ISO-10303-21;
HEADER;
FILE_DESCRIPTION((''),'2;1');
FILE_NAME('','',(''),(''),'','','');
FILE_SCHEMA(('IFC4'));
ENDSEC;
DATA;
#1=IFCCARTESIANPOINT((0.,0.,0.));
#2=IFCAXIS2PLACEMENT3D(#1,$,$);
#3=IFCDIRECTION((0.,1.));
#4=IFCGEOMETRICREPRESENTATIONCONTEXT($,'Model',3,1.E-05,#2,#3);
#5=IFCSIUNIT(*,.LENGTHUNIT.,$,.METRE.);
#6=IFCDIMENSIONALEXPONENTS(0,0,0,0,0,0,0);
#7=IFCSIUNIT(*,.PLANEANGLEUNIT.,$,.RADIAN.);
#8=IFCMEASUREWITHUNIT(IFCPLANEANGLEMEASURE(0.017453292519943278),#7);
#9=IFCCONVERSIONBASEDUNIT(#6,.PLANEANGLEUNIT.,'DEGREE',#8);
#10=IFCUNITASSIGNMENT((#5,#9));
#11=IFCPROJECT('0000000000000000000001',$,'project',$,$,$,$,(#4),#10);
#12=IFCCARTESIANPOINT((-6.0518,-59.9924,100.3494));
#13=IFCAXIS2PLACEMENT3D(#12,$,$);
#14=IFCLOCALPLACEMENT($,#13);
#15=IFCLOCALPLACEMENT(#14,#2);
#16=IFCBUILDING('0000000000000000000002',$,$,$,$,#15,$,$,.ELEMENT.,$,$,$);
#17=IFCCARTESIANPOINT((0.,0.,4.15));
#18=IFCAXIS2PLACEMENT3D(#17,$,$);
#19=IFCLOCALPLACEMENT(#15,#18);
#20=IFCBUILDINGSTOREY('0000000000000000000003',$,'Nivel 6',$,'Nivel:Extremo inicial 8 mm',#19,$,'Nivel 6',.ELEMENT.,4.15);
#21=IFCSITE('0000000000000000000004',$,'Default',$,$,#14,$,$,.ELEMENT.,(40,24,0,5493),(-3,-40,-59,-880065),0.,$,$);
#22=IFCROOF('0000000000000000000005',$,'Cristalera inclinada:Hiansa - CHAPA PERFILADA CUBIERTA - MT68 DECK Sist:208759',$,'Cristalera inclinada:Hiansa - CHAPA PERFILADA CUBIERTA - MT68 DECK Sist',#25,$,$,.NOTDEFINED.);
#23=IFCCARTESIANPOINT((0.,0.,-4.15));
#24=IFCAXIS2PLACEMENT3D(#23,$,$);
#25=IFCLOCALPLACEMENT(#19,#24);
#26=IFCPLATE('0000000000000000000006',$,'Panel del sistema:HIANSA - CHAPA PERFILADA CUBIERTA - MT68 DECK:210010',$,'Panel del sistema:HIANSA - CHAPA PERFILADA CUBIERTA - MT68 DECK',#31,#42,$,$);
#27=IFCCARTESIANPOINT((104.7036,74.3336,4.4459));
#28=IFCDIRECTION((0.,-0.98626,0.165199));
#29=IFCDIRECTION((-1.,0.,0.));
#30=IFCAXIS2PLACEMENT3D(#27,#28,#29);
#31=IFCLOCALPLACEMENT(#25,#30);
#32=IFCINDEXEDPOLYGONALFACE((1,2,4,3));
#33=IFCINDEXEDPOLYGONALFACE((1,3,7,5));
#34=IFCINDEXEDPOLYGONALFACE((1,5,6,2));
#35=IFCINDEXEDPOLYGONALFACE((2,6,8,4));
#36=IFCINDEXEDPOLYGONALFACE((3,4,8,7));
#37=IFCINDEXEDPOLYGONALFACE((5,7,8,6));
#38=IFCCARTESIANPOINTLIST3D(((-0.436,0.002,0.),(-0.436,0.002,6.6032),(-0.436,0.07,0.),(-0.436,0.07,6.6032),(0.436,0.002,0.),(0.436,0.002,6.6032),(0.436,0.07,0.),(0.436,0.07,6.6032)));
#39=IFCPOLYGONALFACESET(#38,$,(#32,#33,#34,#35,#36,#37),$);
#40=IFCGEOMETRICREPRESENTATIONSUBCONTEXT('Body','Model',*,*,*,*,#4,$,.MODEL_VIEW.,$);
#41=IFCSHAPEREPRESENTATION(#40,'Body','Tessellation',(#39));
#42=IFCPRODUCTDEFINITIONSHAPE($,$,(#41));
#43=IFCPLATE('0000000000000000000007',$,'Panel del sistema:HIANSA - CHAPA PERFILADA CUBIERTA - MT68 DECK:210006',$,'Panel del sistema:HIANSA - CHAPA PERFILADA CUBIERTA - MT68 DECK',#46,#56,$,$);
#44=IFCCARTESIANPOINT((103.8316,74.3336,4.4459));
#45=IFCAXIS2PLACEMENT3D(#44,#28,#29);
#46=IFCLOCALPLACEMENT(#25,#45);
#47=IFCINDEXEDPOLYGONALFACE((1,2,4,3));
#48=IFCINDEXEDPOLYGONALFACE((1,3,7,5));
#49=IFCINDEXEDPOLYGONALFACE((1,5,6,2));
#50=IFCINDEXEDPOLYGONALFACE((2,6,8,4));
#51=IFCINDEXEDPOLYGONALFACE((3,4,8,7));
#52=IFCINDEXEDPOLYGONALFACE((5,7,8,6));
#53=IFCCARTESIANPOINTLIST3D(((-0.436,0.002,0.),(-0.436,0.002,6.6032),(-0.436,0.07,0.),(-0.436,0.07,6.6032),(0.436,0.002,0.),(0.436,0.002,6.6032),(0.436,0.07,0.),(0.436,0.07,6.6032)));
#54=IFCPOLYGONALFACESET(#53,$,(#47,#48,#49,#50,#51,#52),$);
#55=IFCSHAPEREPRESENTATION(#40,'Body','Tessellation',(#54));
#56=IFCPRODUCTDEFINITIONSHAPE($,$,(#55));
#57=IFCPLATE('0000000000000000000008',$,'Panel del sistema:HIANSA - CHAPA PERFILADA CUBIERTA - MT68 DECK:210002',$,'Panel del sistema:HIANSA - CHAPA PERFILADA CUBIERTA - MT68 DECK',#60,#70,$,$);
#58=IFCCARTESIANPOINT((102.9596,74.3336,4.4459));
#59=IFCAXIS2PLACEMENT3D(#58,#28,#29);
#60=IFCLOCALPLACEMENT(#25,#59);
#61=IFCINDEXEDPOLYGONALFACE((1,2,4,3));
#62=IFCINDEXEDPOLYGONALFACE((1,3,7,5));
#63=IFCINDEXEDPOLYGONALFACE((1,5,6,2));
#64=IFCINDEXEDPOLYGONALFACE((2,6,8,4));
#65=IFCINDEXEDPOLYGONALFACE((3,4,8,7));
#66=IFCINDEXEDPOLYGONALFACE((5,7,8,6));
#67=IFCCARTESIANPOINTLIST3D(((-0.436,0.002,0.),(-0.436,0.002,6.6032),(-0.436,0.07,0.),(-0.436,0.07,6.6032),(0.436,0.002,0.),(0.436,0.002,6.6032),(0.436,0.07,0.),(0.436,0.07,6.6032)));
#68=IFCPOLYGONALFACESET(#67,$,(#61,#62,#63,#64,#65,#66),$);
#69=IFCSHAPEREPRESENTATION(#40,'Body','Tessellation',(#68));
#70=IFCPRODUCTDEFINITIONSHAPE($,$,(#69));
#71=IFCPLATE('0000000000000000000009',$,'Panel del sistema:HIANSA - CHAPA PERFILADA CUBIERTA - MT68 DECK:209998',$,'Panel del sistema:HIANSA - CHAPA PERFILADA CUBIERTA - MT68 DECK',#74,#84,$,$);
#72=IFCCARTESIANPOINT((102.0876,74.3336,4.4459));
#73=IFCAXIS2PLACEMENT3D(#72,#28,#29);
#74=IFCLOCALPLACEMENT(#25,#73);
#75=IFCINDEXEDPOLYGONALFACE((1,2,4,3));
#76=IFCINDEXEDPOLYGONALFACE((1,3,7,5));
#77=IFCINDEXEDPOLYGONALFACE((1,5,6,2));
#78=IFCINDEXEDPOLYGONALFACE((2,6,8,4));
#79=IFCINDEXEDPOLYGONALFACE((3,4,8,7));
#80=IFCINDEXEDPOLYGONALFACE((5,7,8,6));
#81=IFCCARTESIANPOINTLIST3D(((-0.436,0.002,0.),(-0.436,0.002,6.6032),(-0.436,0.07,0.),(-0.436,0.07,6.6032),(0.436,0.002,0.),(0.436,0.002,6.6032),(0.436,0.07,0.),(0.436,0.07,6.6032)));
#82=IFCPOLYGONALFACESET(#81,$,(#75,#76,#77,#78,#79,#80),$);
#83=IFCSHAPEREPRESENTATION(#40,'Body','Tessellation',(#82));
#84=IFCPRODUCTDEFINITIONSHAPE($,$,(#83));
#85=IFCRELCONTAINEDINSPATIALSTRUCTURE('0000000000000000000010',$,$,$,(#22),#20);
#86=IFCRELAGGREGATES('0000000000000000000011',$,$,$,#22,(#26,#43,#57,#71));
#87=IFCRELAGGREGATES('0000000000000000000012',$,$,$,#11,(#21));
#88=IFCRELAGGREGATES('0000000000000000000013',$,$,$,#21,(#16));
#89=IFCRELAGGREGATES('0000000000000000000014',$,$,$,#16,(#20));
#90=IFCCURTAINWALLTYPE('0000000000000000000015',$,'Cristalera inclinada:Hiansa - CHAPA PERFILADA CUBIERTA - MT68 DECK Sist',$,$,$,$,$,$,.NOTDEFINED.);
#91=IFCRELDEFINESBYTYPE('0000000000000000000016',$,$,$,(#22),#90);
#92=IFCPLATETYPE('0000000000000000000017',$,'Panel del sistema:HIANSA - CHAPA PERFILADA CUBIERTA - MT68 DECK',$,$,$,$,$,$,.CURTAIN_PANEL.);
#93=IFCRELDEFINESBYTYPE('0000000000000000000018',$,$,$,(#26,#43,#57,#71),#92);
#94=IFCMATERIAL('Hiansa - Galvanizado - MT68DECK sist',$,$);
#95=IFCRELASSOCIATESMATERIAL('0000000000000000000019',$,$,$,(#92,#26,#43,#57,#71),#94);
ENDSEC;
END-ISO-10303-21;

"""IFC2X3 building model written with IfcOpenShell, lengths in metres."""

from ifc_helpers import new_model, entity, si_unit, converted_unit, direction, frame, origin, origin_2d_with_axis, place, context, subcontext, project, spatial, rectangle, extrude, source, transform, mapped, material, type_object, type_shapes, element, aggregate, save


model = new_model("IFC2X3")

# Units and contexts
model_context = context("Model", 3, precision=1e-05, world=origin(), true_north=direction((0.0, 1.0)))
body_context = subcontext(model_context, "Body", "Model", "MODEL_VIEW")
ifc_project = project(units=[si_unit("LENGTHUNIT", "METRE"), converted_unit("PLANEANGLEUNIT", "DEGREE", entity("IfcPlaneAngleMeasure", 0.017453292519943278), si_unit("PLANEANGLEUNIT", "RADIAN"), dimensions=[0, 0, 0, 0, 0, 0, 0])], contexts=[model_context])

# Site, building, storey
site_placement = place(None, frame((-6.0518, -59.9924, 100.3494)))
site = spatial("IfcSite", under=ifc_project, at=site_placement, Name="Default", CompositionType="ELEMENT", RefLatitude=(40, 24, 0, 5493), RefLongitude=(-3, -40, -59, -880065), RefElevation=0.0)
building_placement = place(site_placement, origin())
building = spatial("IfcBuilding", under=site, at=building_placement, CompositionType="ELEMENT")
storey_placement = place(building_placement, frame((0.0, 0.0, 4.15)))
storey = spatial("IfcBuildingStorey", under=building, at=storey_placement, Name="Nivel 6", ObjectType="Nivel:Extremo inicial 8 mm", LongName="Nivel 6", CompositionType="ELEMENT", Elevation=4.15)

# Roof, plates
curtain_wall_type = type_object("IfcCurtainWallType", Name="Cristalera inclinada:Hiansa - CHAPA PERFILADA CUBIERTA - MT68 DECK Sist", PredefinedType="NOTDEFINED")
roof_placement = place(storey_placement, frame((0.0, 0.0, -4.15)))
roof = element("IfcRoof", 1, at=roof_placement, inside=storey, type_object=curtain_wall_type, Name="Cristalera inclinada:Hiansa - CHAPA PERFILADA CUBIERTA - MT68 DECK Sist:208759", ObjectType="Cristalera inclinada:Hiansa - CHAPA PERFILADA CUBIERTA - MT68 DECK Sist", ShapeType="NOTDEFINED")
ifc_material_1 = material(Name="Hiansa - Galvanizado - MT68DECK sist")
plate_type_1 = type_object("IfcPlateType", Name="Panel del sistema:HIANSA - CHAPA PERFILADA CUBIERTA - MT68 DECK", PredefinedType="CURTAIN_PANEL", material=ifc_material_1)
shared_shape_1 = source(origin(), body_context, "Body", "SweptSolid", [
    extrude(rectangle(XDim=0.068, YDim=0.872, at=origin_2d_with_axis()), frame((0.0, 0.036, 0.0), z_axis=(0.0, 0.0, 1.0), x_axis=(0.0, 1.0, 0.0)), (0.0, 0.0, 1.0), 6.6032),
])
type_shapes(plate_type_1, [shared_shape_1])
plate_1_placement = place(roof_placement, frame((104.7036, 74.3336, 4.4459), z_axis=(0.0, -0.98626, 0.165199), x_axis=(-1.0, 0.0, 0.0)))
plate_1 = element("IfcPlate", 2, at=plate_1_placement, type_object=plate_type_1, material=ifc_material_1, Name="Panel del sistema:HIANSA - CHAPA PERFILADA CUBIERTA - MT68 DECK:210010", ObjectType="Panel del sistema:HIANSA - CHAPA PERFILADA CUBIERTA - MT68 DECK", context=body_context, shape_type="MappedRepresentation", body=[
    mapped(shared_shape_1, transform((0.0, 0.0, 0.0), scale=1.0)),
])
plate_2_placement = place(roof_placement, frame((103.8316, 74.3336, 4.4459), z_axis=(0.0, -0.98626, 0.165199), x_axis=(-1.0, 0.0, 0.0)))
plate_2 = element("IfcPlate", 3, at=plate_2_placement, type_object=plate_type_1, material=ifc_material_1, Name="Panel del sistema:HIANSA - CHAPA PERFILADA CUBIERTA - MT68 DECK:210006", ObjectType="Panel del sistema:HIANSA - CHAPA PERFILADA CUBIERTA - MT68 DECK", context=body_context, shape_type="MappedRepresentation", body=[
    mapped(shared_shape_1, transform((0.0, 0.0, 0.0), scale=1.0)),
])
plate_3_placement = place(roof_placement, frame((102.9596, 74.3336, 4.4459), z_axis=(0.0, -0.98626, 0.165199), x_axis=(-1.0, 0.0, 0.0)))
plate_3 = element("IfcPlate", 4, at=plate_3_placement, type_object=plate_type_1, material=ifc_material_1, Name="Panel del sistema:HIANSA - CHAPA PERFILADA CUBIERTA - MT68 DECK:210002", ObjectType="Panel del sistema:HIANSA - CHAPA PERFILADA CUBIERTA - MT68 DECK", context=body_context, shape_type="MappedRepresentation", body=[
    mapped(shared_shape_1, transform((0.0, 0.0, 0.0), scale=1.0)),
])
plate_4_placement = place(roof_placement, frame((102.0876, 74.3336, 4.4459), z_axis=(0.0, -0.98626, 0.165199), x_axis=(-1.0, 0.0, 0.0)))
plate_4 = element("IfcPlate", 5, at=plate_4_placement, type_object=plate_type_1, material=ifc_material_1, Name="Panel del sistema:HIANSA - CHAPA PERFILADA CUBIERTA - MT68 DECK:209998", ObjectType="Panel del sistema:HIANSA - CHAPA PERFILADA CUBIERTA - MT68 DECK", context=body_context, shape_type="MappedRepresentation", body=[
    mapped(shared_shape_1, transform((0.0, 0.0, 0.0), scale=1.0)),
])
aggregate(roof, [plate_1, plate_2, plate_3, plate_4])

save(model, "model.ifc")
